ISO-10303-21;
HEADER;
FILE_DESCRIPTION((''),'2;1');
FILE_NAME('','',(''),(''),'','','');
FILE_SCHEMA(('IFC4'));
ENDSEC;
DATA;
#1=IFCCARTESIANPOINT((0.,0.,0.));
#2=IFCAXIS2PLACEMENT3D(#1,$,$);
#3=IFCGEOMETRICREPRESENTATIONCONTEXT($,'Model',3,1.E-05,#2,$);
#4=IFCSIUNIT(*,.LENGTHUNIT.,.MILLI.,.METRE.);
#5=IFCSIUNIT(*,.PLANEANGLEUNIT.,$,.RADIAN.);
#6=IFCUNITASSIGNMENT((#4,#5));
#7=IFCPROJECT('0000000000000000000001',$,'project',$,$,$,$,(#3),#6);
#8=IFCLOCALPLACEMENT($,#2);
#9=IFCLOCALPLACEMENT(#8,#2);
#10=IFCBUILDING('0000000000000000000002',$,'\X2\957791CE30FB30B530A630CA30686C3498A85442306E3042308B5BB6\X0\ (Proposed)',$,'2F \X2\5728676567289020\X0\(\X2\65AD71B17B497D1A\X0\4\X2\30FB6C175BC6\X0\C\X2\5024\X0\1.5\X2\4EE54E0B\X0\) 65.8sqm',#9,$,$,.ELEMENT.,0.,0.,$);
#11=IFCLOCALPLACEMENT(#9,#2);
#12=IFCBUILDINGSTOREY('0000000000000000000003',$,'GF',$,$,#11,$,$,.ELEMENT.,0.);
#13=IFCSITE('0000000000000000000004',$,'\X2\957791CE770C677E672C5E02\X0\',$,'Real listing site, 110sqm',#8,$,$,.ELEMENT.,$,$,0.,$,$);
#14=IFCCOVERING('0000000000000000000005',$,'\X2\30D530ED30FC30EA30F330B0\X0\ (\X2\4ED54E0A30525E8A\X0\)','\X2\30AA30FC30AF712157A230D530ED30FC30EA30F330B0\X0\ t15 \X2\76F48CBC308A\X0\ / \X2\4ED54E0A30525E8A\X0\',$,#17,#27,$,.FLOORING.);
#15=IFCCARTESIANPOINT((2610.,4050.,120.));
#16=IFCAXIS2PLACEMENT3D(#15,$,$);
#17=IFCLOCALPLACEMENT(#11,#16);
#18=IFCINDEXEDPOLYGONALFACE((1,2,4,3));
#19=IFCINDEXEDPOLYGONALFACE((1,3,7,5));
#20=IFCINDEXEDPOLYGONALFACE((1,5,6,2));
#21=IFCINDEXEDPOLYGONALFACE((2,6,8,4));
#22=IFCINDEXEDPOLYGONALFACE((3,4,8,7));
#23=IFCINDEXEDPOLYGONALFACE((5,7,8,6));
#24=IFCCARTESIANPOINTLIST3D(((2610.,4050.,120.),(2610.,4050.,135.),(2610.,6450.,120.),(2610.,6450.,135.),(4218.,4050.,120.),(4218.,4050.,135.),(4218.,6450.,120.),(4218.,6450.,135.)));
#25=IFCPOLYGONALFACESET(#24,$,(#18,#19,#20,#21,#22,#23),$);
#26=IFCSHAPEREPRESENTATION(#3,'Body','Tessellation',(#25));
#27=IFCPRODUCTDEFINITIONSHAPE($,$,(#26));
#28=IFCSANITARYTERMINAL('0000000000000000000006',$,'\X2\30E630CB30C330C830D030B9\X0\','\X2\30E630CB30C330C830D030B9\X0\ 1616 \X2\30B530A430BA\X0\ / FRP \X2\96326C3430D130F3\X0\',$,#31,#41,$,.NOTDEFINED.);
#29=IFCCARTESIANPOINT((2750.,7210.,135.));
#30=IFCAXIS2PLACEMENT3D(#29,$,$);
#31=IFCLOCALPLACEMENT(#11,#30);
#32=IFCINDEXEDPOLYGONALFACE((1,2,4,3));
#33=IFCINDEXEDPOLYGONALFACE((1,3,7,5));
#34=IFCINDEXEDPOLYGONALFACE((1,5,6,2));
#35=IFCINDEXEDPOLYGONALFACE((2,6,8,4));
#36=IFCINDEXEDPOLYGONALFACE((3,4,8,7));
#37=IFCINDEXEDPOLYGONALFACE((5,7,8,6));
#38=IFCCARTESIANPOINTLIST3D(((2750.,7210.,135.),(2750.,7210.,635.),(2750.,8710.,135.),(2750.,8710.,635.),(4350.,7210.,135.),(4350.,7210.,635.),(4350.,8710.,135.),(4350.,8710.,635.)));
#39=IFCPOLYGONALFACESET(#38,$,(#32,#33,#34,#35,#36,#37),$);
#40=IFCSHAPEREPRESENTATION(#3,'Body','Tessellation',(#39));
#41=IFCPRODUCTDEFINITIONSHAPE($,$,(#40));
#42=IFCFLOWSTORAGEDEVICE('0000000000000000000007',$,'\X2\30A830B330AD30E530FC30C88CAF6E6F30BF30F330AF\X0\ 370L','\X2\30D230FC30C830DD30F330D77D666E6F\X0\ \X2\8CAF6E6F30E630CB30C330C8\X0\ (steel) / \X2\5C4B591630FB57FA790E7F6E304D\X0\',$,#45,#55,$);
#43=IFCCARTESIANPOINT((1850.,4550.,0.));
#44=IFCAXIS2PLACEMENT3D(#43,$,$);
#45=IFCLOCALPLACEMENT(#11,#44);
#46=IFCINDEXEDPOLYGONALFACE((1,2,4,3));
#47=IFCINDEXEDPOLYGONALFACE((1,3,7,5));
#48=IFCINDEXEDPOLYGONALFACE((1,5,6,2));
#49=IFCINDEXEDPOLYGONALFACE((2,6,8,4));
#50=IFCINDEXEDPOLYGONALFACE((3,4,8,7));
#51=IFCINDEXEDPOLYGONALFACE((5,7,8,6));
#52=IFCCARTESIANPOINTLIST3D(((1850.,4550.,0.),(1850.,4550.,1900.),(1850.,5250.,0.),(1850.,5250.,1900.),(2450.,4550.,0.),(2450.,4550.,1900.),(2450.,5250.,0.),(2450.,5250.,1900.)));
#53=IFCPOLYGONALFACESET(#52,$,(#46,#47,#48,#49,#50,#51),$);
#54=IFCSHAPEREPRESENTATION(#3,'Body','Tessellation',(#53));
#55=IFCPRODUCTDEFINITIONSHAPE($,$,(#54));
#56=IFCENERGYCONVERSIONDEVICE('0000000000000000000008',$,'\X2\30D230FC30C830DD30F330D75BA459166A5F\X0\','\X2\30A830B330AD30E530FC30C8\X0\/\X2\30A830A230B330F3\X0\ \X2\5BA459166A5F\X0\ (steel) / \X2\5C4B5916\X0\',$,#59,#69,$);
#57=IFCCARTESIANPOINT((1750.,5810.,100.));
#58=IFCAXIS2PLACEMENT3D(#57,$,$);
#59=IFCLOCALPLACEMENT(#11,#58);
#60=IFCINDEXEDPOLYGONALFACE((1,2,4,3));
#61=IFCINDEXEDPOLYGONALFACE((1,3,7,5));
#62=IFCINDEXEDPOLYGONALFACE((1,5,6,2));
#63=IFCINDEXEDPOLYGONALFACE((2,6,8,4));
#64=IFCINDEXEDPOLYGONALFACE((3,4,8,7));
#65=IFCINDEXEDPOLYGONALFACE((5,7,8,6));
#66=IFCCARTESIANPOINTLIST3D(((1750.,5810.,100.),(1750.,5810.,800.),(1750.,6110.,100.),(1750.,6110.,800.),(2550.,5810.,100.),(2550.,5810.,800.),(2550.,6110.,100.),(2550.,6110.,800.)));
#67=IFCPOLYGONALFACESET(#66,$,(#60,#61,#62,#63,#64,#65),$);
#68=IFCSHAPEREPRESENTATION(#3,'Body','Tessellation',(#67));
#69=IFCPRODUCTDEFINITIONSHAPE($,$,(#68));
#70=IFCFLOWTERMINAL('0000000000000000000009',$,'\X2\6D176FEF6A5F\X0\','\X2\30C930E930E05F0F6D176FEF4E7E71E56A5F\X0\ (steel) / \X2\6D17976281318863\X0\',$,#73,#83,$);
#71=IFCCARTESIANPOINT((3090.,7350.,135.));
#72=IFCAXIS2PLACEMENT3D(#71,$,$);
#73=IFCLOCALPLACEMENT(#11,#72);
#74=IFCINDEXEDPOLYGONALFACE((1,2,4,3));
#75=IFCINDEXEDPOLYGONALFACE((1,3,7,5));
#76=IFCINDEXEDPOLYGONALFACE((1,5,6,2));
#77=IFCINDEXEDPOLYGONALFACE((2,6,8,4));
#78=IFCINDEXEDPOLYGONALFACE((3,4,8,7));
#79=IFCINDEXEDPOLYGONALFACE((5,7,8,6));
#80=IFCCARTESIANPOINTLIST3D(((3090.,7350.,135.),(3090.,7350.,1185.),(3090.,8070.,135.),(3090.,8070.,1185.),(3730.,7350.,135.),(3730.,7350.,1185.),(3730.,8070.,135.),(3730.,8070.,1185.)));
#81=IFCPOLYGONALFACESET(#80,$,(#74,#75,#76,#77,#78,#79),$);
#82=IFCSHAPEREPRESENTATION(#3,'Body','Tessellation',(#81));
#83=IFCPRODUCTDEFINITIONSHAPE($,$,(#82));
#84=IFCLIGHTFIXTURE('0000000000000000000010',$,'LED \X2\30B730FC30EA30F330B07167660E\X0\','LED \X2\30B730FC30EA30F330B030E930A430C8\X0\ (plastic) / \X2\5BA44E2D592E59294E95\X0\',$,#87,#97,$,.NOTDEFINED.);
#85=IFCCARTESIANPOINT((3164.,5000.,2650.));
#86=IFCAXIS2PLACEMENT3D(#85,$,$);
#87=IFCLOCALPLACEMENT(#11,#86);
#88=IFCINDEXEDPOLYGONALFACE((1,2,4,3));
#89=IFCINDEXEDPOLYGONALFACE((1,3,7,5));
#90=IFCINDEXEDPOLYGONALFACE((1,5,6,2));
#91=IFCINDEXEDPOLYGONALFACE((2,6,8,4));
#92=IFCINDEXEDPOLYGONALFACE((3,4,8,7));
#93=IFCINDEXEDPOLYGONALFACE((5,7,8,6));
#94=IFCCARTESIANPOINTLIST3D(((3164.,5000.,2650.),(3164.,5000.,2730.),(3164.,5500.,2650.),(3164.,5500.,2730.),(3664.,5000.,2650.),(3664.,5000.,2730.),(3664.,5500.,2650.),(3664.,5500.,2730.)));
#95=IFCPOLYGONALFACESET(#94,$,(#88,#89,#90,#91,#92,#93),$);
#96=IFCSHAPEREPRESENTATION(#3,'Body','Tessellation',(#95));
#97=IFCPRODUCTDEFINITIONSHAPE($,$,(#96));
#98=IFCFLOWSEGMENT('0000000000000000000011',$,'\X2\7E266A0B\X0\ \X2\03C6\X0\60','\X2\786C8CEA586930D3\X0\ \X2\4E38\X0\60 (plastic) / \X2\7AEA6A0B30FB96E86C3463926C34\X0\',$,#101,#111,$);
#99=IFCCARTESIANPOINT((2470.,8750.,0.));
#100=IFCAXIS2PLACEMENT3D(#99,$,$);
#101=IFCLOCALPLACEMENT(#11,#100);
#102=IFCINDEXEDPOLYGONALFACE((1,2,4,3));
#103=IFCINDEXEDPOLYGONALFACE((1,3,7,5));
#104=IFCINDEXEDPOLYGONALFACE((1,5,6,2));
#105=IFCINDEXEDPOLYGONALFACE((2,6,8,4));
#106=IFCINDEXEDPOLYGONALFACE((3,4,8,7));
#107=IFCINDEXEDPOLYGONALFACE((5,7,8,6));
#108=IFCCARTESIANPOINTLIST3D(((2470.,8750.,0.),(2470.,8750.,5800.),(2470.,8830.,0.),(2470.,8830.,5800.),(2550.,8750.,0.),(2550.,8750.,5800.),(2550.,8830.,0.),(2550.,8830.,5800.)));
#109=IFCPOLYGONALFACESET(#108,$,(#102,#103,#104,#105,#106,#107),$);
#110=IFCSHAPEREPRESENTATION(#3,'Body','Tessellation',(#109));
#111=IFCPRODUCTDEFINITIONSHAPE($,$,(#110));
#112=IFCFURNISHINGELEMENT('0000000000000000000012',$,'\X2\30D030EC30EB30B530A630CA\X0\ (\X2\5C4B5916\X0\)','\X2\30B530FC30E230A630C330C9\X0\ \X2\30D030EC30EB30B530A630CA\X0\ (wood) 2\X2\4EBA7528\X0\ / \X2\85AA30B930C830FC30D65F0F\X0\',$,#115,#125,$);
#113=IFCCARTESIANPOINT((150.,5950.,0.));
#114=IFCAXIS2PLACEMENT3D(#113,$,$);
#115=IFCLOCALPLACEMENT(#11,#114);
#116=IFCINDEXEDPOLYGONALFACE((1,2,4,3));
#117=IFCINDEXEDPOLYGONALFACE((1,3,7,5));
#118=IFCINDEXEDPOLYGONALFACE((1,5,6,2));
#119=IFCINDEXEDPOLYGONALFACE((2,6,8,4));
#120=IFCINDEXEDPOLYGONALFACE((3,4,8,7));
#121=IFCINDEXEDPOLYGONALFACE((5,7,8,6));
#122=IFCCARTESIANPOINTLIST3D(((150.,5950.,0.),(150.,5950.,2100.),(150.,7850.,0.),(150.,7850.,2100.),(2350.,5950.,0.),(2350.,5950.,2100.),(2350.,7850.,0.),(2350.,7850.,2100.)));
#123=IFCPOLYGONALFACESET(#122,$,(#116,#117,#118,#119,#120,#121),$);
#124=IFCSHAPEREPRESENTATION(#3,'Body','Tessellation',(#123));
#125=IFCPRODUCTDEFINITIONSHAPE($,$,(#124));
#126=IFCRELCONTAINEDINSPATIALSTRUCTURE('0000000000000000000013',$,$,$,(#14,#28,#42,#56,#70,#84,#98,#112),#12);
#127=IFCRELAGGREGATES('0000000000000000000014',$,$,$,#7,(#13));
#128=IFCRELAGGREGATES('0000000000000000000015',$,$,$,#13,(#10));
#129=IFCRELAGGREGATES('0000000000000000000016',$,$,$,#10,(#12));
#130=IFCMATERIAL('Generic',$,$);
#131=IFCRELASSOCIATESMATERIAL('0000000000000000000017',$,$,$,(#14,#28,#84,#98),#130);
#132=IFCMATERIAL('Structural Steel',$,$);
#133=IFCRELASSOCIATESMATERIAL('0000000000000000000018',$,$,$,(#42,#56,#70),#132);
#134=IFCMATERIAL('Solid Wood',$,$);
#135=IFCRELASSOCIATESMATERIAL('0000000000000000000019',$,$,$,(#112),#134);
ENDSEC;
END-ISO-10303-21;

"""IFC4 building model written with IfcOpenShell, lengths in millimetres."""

from ifc_helpers import new_model, si_unit, frame, frame_2d, origin, place, context, project, spatial, rectangle, extrude, material, element, save


model = new_model("IFC4")

# Units and contexts
model_context = context("Model", 3, precision=1e-05, world=origin())
ifc_project = project(units=[si_unit("LENGTHUNIT", "METRE", prefix="MILLI"), si_unit("PLANEANGLEUNIT", "RADIAN")], contexts=[model_context])

# Site, building, storey
site_placement = place(None, origin())
site = spatial("IfcSite", under=ifc_project, at=site_placement, Name="長野県松本市", ObjectType="Real listing site, 110sqm", CompositionType="ELEMENT", RefElevation=0.0)
building_placement = place(site_placement, origin())
building = spatial("IfcBuilding", under=site, at=building_placement, Name="長野・サウナと水風呂のある家 (Proposed)", ObjectType="2F 在来木造(断熱等級4・気密C値1.5以下) 65.8sqm", CompositionType="ELEMENT", ElevationOfRefHeight=0.0, ElevationOfTerrain=0.0)
storey_placement = place(building_placement, origin())
storey = spatial("IfcBuildingStorey", under=building, at=storey_placement, Name="GF", CompositionType="ELEMENT", Elevation=0.0)

# Shared definitions
ifc_material_1 = material(Name="Solid Wood")

# Covering
ifc_material_2 = material(Name="Generic")
covering_1_placement = place(storey_placement, frame((2610.0, 4050.0, 120.0)))
element("IfcCovering", 1, at=covering_1_placement, inside=storey, material=ifc_material_2, Name="フローリング (仕上げ床)", Description="オーク無垢フローリング t15 直貼り / 仕上げ床", PredefinedType="FLOORING", context=model_context, shape_type="SweptSolid", body=[
    extrude(rectangle(XDim=1608.0, YDim=2400.0, at=frame_2d((804.0, 1200.0))), frame((2610.0, 4050.0, 120.0)), (0.0, 0.0, 1.0), 15.0),
])

# Sanitary terminal
sanitary_terminal_placement = place(storey_placement, frame((2750.0, 7210.0, 135.0)))
element("IfcSanitaryTerminal", 2, at=sanitary_terminal_placement, inside=storey, material=ifc_material_2, Name="ユニットバス", Description="ユニットバス 1616 サイズ / FRP 防水パン", PredefinedType="NOTDEFINED", context=model_context, shape_type="SweptSolid", body=[
    extrude(rectangle(XDim=1600.0, YDim=1500.0, at=frame_2d((800.0, 750.0))), frame((2750.0, 7210.0, 135.0)), (0.0, 0.0, 1.0), 500.0),
])

# Flow storage device
ifc_material_3 = material(Name="Structural Steel")
flow_storage_device_placement = place(storey_placement, frame((1850.0, 4550.0, 0.0)))
element("IfcFlowStorageDevice", 3, at=flow_storage_device_placement, inside=storey, material=ifc_material_3, Name="エコキュート貯湯タンク 370L", Description="ヒートポンプ給湯 貯湯ユニット (steel) / 屋外・基礎置き", context=model_context, shape_type="SweptSolid", body=[
    extrude(rectangle(XDim=600.0, YDim=700.0, at=frame_2d((300.0, 350.0))), frame((1850.0, 4550.0, 0.0)), (0.0, 0.0, 1.0), 1900.0),
])

# Energy conversion device
energy_conversion_device_placement = place(storey_placement, frame((1750.0, 5810.0, 100.0)))
element("IfcEnergyConversionDevice", 4, at=energy_conversion_device_placement, inside=storey, material=ifc_material_3, Name="ヒートポンプ室外機", Description="エコキュート/エアコン 室外機 (steel) / 屋外", context=model_context, shape_type="SweptSolid", body=[
    extrude(rectangle(XDim=800.0, YDim=300.0, at=frame_2d((400.0, 150.0))), frame((1750.0, 5810.0, 100.0)), (0.0, 0.0, 1.0), 700.0),
])

# Flow terminal
flow_terminal_placement = place(storey_placement, frame((3090.0, 7350.0, 135.0)))
element("IfcFlowTerminal", 5, at=flow_terminal_placement, inside=storey, material=ifc_material_3, Name="洗濯機", Description="ドラム式洗濯乾燥機 (steel) / 洗面脱衣", context=model_context, shape_type="SweptSolid", body=[
    extrude(rectangle(XDim=640.0, YDim=720.0, at=frame_2d((320.0, 360.0))), frame((3090.0, 7350.0, 135.0)), (0.0, 0.0, 1.0), 1050.0),
])

# Light fixture
light_fixture_placement = place(storey_placement, frame((3164.0, 5000.0, 2650.0)))
element("IfcLightFixture", 6, at=light_fixture_placement, inside=storey, material=ifc_material_2, Name="LED シーリング照明", Description="LED シーリングライト (plastic) / 室中央天井", PredefinedType="NOTDEFINED", context=model_context, shape_type="SweptSolid", body=[
    extrude(rectangle(XDim=500.0, YDim=500.0, at=frame_2d((250.0, 250.0))), frame((3164.0, 5000.0, 2650.0)), (0.0, 0.0, 1.0), 80.0),
])

# Flow segment
flow_segment_placement = place(storey_placement, frame((2470.0, 8750.0, 0.0)))
element("IfcFlowSegment", 7, at=flow_segment_placement, inside=storey, material=ifc_material_2, Name="縦樋 φ60", Description="硬質塩ビ 丸60 (plastic) / 竪樋・雨水排水", context=model_context, shape_type="SweptSolid", body=[
    extrude(rectangle(XDim=80.0, YDim=80.0, at=frame_2d((40.0, 40.0))), frame((2470.0, 8750.0, 0.0)), (0.0, 0.0, 1.0), 5800.0),
])

# Furnishing element
furnishing_placement = place(storey_placement, frame((150.0, 5950.0, 0.0)))
element("IfcFurnishingElement", 8, at=furnishing_placement, inside=storey, material=ifc_material_1, Name="バレルサウナ (屋外)", Description="サーモウッド バレルサウナ (wood) 2人用 / 薪ストーブ式", context=model_context, shape_type="SweptSolid", body=[
    extrude(rectangle(XDim=2200.0, YDim=1900.0, at=frame_2d((1100.0, 950.0))), frame((150.0, 5950.0, 0.0)), (0.0, 0.0, 1.0), 2100.0),
])

save(model, "model.ifc")
